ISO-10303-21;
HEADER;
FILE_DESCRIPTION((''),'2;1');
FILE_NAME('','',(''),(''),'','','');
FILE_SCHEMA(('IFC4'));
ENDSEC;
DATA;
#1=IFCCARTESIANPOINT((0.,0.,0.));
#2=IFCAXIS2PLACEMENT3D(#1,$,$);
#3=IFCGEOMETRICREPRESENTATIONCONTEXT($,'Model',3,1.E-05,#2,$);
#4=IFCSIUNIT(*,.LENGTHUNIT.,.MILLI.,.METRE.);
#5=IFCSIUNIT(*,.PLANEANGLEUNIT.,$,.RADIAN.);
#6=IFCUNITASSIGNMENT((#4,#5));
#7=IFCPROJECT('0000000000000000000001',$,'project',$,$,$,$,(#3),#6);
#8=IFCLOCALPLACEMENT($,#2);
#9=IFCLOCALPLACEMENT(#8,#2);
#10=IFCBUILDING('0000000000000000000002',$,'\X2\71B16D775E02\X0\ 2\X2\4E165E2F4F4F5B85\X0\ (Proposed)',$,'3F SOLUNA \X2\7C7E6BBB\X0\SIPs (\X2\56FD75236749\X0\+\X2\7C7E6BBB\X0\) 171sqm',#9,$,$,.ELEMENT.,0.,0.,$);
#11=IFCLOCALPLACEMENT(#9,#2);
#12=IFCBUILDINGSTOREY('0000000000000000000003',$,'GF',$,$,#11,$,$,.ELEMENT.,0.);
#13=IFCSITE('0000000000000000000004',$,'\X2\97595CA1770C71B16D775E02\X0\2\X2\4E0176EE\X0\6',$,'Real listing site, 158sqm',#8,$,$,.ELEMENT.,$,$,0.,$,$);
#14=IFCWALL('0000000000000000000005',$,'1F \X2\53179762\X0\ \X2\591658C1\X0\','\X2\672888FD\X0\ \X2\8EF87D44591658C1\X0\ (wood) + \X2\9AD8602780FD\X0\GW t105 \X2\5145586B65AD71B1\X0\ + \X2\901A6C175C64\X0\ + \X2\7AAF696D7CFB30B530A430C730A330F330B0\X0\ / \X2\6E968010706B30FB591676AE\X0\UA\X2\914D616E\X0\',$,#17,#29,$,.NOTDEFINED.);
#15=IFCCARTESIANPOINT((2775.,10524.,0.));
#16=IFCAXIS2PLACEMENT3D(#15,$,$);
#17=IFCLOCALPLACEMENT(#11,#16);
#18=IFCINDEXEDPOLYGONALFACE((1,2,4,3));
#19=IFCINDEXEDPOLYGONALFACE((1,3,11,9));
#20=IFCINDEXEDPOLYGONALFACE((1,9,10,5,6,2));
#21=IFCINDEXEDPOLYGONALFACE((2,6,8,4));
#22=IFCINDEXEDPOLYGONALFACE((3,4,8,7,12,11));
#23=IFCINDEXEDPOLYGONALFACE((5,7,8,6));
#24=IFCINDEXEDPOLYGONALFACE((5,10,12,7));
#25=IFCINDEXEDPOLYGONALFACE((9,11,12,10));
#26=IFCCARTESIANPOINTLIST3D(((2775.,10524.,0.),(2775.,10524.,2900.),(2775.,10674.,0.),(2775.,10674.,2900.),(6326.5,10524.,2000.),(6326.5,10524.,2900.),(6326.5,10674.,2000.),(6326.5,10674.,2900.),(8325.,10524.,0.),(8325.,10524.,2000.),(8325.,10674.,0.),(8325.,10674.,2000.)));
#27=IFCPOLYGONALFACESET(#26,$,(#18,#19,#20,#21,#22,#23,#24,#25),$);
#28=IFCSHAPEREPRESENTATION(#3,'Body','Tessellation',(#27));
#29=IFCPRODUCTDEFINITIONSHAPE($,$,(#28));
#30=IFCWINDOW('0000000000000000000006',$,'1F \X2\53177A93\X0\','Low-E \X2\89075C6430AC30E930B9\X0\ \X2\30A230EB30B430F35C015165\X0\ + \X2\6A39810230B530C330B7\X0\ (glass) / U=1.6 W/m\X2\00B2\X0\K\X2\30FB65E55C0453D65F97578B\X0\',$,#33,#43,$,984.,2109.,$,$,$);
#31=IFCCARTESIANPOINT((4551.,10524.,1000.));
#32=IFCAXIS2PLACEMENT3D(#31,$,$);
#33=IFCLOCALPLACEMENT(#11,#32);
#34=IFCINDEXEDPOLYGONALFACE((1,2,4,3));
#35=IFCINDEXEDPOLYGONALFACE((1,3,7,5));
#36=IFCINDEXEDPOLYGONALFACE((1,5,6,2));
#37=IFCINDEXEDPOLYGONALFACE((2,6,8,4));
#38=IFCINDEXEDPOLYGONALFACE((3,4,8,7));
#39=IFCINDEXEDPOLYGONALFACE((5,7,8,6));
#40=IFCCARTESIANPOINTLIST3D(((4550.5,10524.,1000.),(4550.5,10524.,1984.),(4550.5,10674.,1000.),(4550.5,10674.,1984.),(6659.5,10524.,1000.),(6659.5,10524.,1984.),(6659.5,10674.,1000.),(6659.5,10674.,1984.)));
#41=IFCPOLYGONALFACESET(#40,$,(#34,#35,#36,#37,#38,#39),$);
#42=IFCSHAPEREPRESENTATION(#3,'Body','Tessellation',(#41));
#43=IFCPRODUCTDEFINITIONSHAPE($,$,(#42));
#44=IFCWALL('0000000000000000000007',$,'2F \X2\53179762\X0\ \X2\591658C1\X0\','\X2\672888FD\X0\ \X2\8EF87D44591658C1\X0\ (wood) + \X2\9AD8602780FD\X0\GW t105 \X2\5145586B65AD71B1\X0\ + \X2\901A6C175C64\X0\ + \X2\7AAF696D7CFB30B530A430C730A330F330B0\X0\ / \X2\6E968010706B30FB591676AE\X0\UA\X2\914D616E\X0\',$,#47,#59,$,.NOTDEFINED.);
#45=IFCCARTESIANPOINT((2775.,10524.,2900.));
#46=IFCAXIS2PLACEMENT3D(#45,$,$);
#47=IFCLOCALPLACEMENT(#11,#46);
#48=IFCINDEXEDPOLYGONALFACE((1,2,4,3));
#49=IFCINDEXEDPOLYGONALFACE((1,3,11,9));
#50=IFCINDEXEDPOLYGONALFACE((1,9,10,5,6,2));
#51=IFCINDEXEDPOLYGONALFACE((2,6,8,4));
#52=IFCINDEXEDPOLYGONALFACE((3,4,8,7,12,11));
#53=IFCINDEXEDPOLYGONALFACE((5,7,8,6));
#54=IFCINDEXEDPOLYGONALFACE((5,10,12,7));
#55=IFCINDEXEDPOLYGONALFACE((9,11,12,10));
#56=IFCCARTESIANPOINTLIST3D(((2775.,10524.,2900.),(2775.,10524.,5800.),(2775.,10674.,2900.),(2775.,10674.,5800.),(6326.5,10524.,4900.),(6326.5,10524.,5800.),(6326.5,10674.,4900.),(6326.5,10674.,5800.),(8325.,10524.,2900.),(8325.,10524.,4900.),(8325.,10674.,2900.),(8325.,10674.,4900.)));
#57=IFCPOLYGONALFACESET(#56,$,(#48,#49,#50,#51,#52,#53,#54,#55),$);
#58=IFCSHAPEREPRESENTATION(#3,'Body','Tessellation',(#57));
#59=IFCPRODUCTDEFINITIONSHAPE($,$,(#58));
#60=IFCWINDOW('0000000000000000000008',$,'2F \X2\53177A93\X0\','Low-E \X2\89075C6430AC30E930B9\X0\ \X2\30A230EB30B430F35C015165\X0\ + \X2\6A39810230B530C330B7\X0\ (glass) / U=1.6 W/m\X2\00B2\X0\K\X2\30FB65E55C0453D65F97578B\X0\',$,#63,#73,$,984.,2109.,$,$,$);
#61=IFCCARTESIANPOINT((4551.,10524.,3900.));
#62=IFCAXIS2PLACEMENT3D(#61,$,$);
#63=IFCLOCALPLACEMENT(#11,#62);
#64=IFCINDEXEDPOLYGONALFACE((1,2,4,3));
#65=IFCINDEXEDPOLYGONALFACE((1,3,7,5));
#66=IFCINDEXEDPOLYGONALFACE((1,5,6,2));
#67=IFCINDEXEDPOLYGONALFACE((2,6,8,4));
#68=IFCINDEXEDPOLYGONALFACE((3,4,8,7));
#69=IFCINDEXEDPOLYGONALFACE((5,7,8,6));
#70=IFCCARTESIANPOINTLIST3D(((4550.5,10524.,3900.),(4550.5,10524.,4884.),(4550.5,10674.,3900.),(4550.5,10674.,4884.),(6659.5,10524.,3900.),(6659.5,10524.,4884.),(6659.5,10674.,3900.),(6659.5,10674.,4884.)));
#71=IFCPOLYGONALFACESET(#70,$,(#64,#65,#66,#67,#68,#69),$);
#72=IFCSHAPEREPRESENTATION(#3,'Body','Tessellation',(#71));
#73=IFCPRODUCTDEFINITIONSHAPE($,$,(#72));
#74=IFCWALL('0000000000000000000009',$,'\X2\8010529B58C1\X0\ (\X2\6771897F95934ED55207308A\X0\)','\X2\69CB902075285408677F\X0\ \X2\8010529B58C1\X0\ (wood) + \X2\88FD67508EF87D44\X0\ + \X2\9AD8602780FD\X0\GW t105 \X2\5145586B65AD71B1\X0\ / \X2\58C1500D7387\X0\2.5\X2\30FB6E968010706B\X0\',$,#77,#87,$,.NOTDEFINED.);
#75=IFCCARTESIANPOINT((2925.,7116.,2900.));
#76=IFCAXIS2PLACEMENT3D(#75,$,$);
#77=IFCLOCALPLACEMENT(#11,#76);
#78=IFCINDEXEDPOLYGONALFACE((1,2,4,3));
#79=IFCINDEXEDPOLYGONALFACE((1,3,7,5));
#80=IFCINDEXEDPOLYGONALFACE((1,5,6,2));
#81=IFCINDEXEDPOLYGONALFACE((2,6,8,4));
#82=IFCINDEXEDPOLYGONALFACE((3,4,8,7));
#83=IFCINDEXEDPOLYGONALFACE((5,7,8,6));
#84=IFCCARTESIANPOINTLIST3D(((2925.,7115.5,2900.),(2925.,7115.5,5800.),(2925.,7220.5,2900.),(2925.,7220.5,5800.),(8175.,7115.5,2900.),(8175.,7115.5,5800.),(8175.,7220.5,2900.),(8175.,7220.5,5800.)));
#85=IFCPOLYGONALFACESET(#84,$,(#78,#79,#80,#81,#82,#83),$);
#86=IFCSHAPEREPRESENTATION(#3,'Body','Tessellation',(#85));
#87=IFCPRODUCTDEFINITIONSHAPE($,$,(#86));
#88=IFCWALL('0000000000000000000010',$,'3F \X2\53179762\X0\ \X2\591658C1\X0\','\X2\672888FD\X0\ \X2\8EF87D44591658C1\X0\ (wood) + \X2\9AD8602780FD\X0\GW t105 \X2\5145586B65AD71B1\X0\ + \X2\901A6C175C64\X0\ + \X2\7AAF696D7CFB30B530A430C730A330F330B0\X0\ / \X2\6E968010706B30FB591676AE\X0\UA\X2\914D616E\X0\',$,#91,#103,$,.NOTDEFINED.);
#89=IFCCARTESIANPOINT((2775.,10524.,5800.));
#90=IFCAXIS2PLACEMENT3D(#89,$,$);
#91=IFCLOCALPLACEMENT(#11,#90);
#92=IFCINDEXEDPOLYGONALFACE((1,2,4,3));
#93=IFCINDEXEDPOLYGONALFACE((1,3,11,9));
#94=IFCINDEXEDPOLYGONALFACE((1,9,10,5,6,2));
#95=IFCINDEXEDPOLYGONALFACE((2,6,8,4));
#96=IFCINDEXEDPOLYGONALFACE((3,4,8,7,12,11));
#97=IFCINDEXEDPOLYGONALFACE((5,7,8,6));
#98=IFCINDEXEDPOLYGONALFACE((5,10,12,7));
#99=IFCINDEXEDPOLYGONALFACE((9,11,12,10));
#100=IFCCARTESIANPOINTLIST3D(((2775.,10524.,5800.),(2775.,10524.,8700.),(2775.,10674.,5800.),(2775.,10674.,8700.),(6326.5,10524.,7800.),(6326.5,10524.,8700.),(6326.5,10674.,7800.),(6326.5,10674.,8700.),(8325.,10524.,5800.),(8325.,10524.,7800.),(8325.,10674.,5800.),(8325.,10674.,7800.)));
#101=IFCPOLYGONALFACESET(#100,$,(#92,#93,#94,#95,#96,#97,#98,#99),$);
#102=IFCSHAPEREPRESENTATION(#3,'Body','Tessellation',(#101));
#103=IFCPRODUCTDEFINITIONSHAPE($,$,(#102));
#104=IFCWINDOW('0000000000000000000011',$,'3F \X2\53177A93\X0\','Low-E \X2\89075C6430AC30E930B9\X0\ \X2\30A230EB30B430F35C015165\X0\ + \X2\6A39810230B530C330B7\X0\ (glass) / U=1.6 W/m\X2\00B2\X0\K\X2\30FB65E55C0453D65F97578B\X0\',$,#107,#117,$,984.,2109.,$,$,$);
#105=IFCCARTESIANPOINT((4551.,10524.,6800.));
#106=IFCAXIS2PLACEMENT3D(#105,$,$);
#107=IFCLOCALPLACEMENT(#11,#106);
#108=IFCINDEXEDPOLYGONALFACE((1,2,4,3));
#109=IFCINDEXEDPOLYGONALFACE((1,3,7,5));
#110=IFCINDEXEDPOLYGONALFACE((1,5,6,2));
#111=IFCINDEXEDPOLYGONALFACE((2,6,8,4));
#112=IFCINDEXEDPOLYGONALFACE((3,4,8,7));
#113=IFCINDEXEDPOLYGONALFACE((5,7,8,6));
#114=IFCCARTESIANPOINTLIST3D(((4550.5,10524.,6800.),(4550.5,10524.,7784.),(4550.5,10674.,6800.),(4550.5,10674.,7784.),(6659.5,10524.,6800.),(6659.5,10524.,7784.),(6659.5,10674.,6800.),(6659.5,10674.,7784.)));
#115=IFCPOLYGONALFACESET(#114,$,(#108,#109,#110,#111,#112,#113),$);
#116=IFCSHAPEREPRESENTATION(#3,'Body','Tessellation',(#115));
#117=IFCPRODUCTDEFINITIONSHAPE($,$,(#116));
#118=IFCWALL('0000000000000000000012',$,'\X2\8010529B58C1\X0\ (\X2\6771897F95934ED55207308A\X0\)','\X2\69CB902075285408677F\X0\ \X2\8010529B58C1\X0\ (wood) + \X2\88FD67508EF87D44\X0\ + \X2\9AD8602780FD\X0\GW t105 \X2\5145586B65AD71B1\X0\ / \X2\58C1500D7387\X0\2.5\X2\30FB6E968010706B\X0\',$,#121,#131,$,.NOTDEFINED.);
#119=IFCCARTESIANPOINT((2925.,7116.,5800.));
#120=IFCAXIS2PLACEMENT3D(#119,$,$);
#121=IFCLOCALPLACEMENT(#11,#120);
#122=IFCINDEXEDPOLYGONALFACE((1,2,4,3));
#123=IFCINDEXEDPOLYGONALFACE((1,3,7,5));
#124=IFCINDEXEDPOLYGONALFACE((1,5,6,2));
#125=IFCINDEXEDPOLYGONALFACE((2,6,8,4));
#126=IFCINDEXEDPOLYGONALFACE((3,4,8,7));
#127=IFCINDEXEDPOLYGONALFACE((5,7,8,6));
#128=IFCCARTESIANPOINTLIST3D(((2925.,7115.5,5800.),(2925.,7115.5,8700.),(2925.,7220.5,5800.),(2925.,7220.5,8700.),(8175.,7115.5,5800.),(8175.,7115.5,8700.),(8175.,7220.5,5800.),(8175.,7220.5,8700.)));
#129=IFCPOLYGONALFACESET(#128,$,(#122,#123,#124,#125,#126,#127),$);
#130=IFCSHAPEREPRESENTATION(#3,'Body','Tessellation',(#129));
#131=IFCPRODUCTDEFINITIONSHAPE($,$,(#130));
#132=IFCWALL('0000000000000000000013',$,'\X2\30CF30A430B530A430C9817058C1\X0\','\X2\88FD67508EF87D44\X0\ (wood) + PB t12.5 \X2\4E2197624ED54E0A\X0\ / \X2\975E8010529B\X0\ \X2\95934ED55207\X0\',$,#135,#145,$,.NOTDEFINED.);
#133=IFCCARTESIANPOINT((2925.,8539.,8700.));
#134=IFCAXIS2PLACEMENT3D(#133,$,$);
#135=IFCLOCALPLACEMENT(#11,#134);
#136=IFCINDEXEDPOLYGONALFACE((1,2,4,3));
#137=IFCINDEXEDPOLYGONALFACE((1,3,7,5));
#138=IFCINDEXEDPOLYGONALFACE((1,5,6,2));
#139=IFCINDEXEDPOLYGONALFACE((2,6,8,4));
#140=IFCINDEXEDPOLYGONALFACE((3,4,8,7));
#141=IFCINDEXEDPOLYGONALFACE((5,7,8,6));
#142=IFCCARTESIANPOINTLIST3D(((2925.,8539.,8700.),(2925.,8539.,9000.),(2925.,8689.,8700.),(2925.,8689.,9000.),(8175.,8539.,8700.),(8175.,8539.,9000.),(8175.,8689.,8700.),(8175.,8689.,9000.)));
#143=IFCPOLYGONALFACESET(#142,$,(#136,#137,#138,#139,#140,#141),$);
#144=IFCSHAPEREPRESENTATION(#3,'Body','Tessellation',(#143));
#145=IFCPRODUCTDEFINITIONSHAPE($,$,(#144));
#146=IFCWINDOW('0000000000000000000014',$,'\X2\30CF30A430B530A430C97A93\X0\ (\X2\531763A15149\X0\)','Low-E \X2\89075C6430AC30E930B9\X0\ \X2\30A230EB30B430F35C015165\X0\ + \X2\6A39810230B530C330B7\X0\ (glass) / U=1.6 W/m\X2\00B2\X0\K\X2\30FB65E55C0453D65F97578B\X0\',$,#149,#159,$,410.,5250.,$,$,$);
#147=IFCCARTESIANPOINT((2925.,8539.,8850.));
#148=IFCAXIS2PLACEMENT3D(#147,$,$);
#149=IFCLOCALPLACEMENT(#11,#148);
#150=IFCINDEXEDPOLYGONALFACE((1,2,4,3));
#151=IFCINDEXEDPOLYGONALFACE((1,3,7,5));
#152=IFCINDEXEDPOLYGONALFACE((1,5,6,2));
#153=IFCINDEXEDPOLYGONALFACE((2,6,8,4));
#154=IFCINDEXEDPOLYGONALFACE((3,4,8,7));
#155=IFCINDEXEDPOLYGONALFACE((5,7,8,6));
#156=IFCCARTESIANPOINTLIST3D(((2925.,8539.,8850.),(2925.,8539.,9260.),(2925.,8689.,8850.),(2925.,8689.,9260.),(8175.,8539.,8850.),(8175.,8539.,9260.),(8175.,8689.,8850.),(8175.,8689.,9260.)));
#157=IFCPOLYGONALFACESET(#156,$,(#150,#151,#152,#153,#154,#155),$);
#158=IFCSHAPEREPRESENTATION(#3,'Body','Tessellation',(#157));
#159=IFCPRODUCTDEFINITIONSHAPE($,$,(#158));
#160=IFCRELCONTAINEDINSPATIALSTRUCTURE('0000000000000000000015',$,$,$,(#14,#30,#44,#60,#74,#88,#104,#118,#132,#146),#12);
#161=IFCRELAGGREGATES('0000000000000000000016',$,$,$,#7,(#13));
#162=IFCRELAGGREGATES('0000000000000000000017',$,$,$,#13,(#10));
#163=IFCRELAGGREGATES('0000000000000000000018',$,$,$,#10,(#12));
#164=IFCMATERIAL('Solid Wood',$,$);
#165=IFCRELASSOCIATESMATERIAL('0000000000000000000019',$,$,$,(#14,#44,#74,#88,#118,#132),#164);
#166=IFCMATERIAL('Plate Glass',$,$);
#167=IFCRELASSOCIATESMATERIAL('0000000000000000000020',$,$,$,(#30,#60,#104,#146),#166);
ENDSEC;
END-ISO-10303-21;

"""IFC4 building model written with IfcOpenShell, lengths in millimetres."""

from ifc_helpers import new_model, si_unit, frame, frame_2d, origin, place, context, project, spatial, rectangle, extrude, material, element, fill, save


model = new_model("IFC4")

# Units and contexts
model_context = context("Model", 3, precision=1e-05, world=origin())
ifc_project = project(units=[si_unit("LENGTHUNIT", "METRE", prefix="MILLI"), si_unit("PLANEANGLEUNIT", "RADIAN")], contexts=[model_context])

# Site, building, storey
site_placement = place(None, origin())
site = spatial("IfcSite", under=ifc_project, at=site_placement, Name="静岡県熱海市2丁目6", ObjectType="Real listing site, 158sqm", CompositionType="ELEMENT", RefElevation=0.0)
building_placement = place(site_placement, origin())
building = spatial("IfcBuilding", under=site, at=building_placement, Name="熱海市 2世帯住宅 (Proposed)", ObjectType="3F SOLUNA 籾殻SIPs (国産杉+籾殻) 171sqm", CompositionType="ELEMENT", ElevationOfRefHeight=0.0, ElevationOfTerrain=0.0)
storey_placement = place(building_placement, origin())
storey = spatial("IfcBuildingStorey", under=building, at=storey_placement, Name="GF", CompositionType="ELEMENT", Elevation=0.0)

# Wall, opening, window
ifc_material_1 = material(Name="Solid Wood")
wall_1_placement = place(storey_placement, frame((2775.0, 10524.0, 0.0)))
wall_1 = element("IfcWall", 1, at=wall_1_placement, inside=storey, material=ifc_material_1, Name="1F 北面 外壁", Description="木製 軸組外壁 (wood) + 高性能GW t105 充填断熱 + 通気層 + 窯業系サイディング / 準耐火・外皮UA配慮", PredefinedType="NOTDEFINED", context=model_context, shape_type="SweptSolid", body=[
    extrude(rectangle(XDim=5550.0, YDim=150.0, at=frame_2d((2775.0, 75.0))), frame((2775.0, 10524.0, 0.0)), (0.0, 0.0, 1.0), 2900.0),
])
opening_1_placement = place(storey_placement, frame((4551.0, 10524.0, 1000.0)))
opening_1 = element("IfcOpeningElement", 2, at=opening_1_placement, cuts=wall_1, PredefinedType="NOTDEFINED", context=model_context, shape_type="SweptSolid", body=[
    extrude(rectangle(XDim=2109.0, YDim=150.0, at=frame_2d((1054.0, 75.0))), frame((4551.0, 10524.0, 1000.0)), (0.0, 0.0, 1.0), 984.0),
])
ifc_material_2 = material(Name="Plate Glass")
window_1_placement = place(storey_placement, frame((4551.0, 10524.0, 1000.0)))
window_1 = element("IfcWindow", 3, at=window_1_placement, inside=storey, material=ifc_material_2, Name="1F 北窓", Description="Low-E 複層ガラス アルゴン封入 + 樹脂サッシ (glass) / U=1.6 W/m²K・日射取得型", OverallHeight=984.0, OverallWidth=2109.0, context=model_context, shape_type="SweptSolid", body=[
    extrude(rectangle(XDim=2109.0, YDim=150.0, at=frame_2d((1054.0, 75.0))), frame((4551.0, 10524.0, 1000.0)), (0.0, 0.0, 1.0), 984.0),
])
fill(opening_1, window_1)

# Wall, opening, window
wall_2_placement = place(storey_placement, frame((2775.0, 10524.0, 2900.0)))
wall_2 = element("IfcWall", 4, at=wall_2_placement, inside=storey, material=ifc_material_1, Name="2F 北面 外壁", Description="木製 軸組外壁 (wood) + 高性能GW t105 充填断熱 + 通気層 + 窯業系サイディング / 準耐火・外皮UA配慮", PredefinedType="NOTDEFINED", context=model_context, shape_type="SweptSolid", body=[
    extrude(rectangle(XDim=5550.0, YDim=150.0, at=frame_2d((2775.0, 75.0))), frame((2775.0, 10524.0, 2900.0)), (0.0, 0.0, 1.0), 2900.0),
])
opening_2_placement = place(storey_placement, frame((4551.0, 10524.0, 3900.0)))
opening_2 = element("IfcOpeningElement", 5, at=opening_2_placement, cuts=wall_2, PredefinedType="NOTDEFINED", context=model_context, shape_type="SweptSolid", body=[
    extrude(rectangle(XDim=2109.0, YDim=150.0, at=frame_2d((1054.0, 75.0))), frame((4551.0, 10524.0, 3900.0)), (0.0, 0.0, 1.0), 984.0),
])
window_2_placement = place(storey_placement, frame((4551.0, 10524.0, 3900.0)))
window_2 = element("IfcWindow", 6, at=window_2_placement, inside=storey, material=ifc_material_2, Name="2F 北窓", Description="Low-E 複層ガラス アルゴン封入 + 樹脂サッシ (glass) / U=1.6 W/m²K・日射取得型", OverallHeight=984.0, OverallWidth=2109.0, context=model_context, shape_type="SweptSolid", body=[
    extrude(rectangle(XDim=2109.0, YDim=150.0, at=frame_2d((1054.0, 75.0))), frame((4551.0, 10524.0, 3900.0)), (0.0, 0.0, 1.0), 984.0),
])
fill(opening_2, window_2)

# Wall
wall_3_placement = place(storey_placement, frame((2925.0, 7116.0, 2900.0)))
element("IfcWall", 7, at=wall_3_placement, inside=storey, material=ifc_material_1, Name="耐力壁 (東西間仕切り)", Description="構造用合板 耐力壁 (wood) + 製材軸組 + 高性能GW t105 充填断熱 / 壁倍率2.5・準耐火", PredefinedType="NOTDEFINED", context=model_context, shape_type="SweptSolid", body=[
    extrude(rectangle(XDim=5250.0, YDim=105.0, at=frame_2d((2625.0, 52.0))), frame((2925.0, 7116.0, 2900.0)), (0.0, 0.0, 1.0), 2900.0),
])

# Wall, opening, window
wall_4_placement = place(storey_placement, frame((2775.0, 10524.0, 5800.0)))
wall_4 = element("IfcWall", 8, at=wall_4_placement, inside=storey, material=ifc_material_1, Name="3F 北面 外壁", Description="木製 軸組外壁 (wood) + 高性能GW t105 充填断熱 + 通気層 + 窯業系サイディング / 準耐火・外皮UA配慮", PredefinedType="NOTDEFINED", context=model_context, shape_type="SweptSolid", body=[
    extrude(rectangle(XDim=5550.0, YDim=150.0, at=frame_2d((2775.0, 75.0))), frame((2775.0, 10524.0, 5800.0)), (0.0, 0.0, 1.0), 2900.0),
])
opening_3_placement = place(storey_placement, frame((4551.0, 10524.0, 6800.0)))
opening_3 = element("IfcOpeningElement", 9, at=opening_3_placement, cuts=wall_4, PredefinedType="NOTDEFINED", context=model_context, shape_type="SweptSolid", body=[
    extrude(rectangle(XDim=2109.0, YDim=150.0, at=frame_2d((1054.0, 75.0))), frame((4551.0, 10524.0, 6800.0)), (0.0, 0.0, 1.0), 984.0),
])
window_3_placement = place(storey_placement, frame((4551.0, 10524.0, 6800.0)))
window_3 = element("IfcWindow", 10, at=window_3_placement, inside=storey, material=ifc_material_2, Name="3F 北窓", Description="Low-E 複層ガラス アルゴン封入 + 樹脂サッシ (glass) / U=1.6 W/m²K・日射取得型", OverallHeight=984.0, OverallWidth=2109.0, context=model_context, shape_type="SweptSolid", body=[
    extrude(rectangle(XDim=2109.0, YDim=150.0, at=frame_2d((1054.0, 75.0))), frame((4551.0, 10524.0, 6800.0)), (0.0, 0.0, 1.0), 984.0),
])
fill(opening_3, window_3)

# Wall
wall_5_placement = place(storey_placement, frame((2925.0, 7116.0, 5800.0)))
element("IfcWall", 11, at=wall_5_placement, inside=storey, material=ifc_material_1, Name="耐力壁 (東西間仕切り)", Description="構造用合板 耐力壁 (wood) + 製材軸組 + 高性能GW t105 充填断熱 / 壁倍率2.5・準耐火", PredefinedType="NOTDEFINED", context=model_context, shape_type="SweptSolid", body=[
    extrude(rectangle(XDim=5250.0, YDim=105.0, at=frame_2d((2625.0, 52.0))), frame((2925.0, 7116.0, 5800.0)), (0.0, 0.0, 1.0), 2900.0),
])

# Wall, opening, window
wall_6_placement = place(storey_placement, frame((2925.0, 8539.0, 8700.0)))
wall_6 = element("IfcWall", 12, at=wall_6_placement, inside=storey, material=ifc_material_1, Name="ハイサイド腰壁", Description="製材軸組 (wood) + PB t12.5 両面仕上 / 非耐力 間仕切", PredefinedType="NOTDEFINED", context=model_context, shape_type="SweptSolid", body=[
    extrude(rectangle(XDim=5250.0, YDim=150.0, at=frame_2d((2625.0, 75.0))), frame((2925.0, 8539.0, 8700.0)), (0.0, 0.0, 1.0), 700.0),
])
opening_4_placement = place(storey_placement, frame((2925.0, 8539.0, 8850.0)))
opening_4 = element("IfcOpeningElement", 13, at=opening_4_placement, cuts=wall_6, PredefinedType="NOTDEFINED", context=model_context, shape_type="SweptSolid", body=[
    extrude(rectangle(XDim=5250.0, YDim=150.0, at=frame_2d((2625.0, 75.0))), frame((2925.0, 8539.0, 8850.0)), (0.0, 0.0, 1.0), 410.0),
])
window_4_placement = place(storey_placement, frame((2925.0, 8539.0, 8850.0)))
window_4 = element("IfcWindow", 14, at=window_4_placement, inside=storey, material=ifc_material_2, Name="ハイサイド窓 (北採光)", Description="Low-E 複層ガラス アルゴン封入 + 樹脂サッシ (glass) / U=1.6 W/m²K・日射取得型", OverallHeight=410.0, OverallWidth=5250.0, context=model_context, shape_type="SweptSolid", body=[
    extrude(rectangle(XDim=5250.0, YDim=150.0, at=frame_2d((2625.0, 75.0))), frame((2925.0, 8539.0, 8850.0)), (0.0, 0.0, 1.0), 410.0),
])
fill(opening_4, window_4)

save(model, "model.ifc")
